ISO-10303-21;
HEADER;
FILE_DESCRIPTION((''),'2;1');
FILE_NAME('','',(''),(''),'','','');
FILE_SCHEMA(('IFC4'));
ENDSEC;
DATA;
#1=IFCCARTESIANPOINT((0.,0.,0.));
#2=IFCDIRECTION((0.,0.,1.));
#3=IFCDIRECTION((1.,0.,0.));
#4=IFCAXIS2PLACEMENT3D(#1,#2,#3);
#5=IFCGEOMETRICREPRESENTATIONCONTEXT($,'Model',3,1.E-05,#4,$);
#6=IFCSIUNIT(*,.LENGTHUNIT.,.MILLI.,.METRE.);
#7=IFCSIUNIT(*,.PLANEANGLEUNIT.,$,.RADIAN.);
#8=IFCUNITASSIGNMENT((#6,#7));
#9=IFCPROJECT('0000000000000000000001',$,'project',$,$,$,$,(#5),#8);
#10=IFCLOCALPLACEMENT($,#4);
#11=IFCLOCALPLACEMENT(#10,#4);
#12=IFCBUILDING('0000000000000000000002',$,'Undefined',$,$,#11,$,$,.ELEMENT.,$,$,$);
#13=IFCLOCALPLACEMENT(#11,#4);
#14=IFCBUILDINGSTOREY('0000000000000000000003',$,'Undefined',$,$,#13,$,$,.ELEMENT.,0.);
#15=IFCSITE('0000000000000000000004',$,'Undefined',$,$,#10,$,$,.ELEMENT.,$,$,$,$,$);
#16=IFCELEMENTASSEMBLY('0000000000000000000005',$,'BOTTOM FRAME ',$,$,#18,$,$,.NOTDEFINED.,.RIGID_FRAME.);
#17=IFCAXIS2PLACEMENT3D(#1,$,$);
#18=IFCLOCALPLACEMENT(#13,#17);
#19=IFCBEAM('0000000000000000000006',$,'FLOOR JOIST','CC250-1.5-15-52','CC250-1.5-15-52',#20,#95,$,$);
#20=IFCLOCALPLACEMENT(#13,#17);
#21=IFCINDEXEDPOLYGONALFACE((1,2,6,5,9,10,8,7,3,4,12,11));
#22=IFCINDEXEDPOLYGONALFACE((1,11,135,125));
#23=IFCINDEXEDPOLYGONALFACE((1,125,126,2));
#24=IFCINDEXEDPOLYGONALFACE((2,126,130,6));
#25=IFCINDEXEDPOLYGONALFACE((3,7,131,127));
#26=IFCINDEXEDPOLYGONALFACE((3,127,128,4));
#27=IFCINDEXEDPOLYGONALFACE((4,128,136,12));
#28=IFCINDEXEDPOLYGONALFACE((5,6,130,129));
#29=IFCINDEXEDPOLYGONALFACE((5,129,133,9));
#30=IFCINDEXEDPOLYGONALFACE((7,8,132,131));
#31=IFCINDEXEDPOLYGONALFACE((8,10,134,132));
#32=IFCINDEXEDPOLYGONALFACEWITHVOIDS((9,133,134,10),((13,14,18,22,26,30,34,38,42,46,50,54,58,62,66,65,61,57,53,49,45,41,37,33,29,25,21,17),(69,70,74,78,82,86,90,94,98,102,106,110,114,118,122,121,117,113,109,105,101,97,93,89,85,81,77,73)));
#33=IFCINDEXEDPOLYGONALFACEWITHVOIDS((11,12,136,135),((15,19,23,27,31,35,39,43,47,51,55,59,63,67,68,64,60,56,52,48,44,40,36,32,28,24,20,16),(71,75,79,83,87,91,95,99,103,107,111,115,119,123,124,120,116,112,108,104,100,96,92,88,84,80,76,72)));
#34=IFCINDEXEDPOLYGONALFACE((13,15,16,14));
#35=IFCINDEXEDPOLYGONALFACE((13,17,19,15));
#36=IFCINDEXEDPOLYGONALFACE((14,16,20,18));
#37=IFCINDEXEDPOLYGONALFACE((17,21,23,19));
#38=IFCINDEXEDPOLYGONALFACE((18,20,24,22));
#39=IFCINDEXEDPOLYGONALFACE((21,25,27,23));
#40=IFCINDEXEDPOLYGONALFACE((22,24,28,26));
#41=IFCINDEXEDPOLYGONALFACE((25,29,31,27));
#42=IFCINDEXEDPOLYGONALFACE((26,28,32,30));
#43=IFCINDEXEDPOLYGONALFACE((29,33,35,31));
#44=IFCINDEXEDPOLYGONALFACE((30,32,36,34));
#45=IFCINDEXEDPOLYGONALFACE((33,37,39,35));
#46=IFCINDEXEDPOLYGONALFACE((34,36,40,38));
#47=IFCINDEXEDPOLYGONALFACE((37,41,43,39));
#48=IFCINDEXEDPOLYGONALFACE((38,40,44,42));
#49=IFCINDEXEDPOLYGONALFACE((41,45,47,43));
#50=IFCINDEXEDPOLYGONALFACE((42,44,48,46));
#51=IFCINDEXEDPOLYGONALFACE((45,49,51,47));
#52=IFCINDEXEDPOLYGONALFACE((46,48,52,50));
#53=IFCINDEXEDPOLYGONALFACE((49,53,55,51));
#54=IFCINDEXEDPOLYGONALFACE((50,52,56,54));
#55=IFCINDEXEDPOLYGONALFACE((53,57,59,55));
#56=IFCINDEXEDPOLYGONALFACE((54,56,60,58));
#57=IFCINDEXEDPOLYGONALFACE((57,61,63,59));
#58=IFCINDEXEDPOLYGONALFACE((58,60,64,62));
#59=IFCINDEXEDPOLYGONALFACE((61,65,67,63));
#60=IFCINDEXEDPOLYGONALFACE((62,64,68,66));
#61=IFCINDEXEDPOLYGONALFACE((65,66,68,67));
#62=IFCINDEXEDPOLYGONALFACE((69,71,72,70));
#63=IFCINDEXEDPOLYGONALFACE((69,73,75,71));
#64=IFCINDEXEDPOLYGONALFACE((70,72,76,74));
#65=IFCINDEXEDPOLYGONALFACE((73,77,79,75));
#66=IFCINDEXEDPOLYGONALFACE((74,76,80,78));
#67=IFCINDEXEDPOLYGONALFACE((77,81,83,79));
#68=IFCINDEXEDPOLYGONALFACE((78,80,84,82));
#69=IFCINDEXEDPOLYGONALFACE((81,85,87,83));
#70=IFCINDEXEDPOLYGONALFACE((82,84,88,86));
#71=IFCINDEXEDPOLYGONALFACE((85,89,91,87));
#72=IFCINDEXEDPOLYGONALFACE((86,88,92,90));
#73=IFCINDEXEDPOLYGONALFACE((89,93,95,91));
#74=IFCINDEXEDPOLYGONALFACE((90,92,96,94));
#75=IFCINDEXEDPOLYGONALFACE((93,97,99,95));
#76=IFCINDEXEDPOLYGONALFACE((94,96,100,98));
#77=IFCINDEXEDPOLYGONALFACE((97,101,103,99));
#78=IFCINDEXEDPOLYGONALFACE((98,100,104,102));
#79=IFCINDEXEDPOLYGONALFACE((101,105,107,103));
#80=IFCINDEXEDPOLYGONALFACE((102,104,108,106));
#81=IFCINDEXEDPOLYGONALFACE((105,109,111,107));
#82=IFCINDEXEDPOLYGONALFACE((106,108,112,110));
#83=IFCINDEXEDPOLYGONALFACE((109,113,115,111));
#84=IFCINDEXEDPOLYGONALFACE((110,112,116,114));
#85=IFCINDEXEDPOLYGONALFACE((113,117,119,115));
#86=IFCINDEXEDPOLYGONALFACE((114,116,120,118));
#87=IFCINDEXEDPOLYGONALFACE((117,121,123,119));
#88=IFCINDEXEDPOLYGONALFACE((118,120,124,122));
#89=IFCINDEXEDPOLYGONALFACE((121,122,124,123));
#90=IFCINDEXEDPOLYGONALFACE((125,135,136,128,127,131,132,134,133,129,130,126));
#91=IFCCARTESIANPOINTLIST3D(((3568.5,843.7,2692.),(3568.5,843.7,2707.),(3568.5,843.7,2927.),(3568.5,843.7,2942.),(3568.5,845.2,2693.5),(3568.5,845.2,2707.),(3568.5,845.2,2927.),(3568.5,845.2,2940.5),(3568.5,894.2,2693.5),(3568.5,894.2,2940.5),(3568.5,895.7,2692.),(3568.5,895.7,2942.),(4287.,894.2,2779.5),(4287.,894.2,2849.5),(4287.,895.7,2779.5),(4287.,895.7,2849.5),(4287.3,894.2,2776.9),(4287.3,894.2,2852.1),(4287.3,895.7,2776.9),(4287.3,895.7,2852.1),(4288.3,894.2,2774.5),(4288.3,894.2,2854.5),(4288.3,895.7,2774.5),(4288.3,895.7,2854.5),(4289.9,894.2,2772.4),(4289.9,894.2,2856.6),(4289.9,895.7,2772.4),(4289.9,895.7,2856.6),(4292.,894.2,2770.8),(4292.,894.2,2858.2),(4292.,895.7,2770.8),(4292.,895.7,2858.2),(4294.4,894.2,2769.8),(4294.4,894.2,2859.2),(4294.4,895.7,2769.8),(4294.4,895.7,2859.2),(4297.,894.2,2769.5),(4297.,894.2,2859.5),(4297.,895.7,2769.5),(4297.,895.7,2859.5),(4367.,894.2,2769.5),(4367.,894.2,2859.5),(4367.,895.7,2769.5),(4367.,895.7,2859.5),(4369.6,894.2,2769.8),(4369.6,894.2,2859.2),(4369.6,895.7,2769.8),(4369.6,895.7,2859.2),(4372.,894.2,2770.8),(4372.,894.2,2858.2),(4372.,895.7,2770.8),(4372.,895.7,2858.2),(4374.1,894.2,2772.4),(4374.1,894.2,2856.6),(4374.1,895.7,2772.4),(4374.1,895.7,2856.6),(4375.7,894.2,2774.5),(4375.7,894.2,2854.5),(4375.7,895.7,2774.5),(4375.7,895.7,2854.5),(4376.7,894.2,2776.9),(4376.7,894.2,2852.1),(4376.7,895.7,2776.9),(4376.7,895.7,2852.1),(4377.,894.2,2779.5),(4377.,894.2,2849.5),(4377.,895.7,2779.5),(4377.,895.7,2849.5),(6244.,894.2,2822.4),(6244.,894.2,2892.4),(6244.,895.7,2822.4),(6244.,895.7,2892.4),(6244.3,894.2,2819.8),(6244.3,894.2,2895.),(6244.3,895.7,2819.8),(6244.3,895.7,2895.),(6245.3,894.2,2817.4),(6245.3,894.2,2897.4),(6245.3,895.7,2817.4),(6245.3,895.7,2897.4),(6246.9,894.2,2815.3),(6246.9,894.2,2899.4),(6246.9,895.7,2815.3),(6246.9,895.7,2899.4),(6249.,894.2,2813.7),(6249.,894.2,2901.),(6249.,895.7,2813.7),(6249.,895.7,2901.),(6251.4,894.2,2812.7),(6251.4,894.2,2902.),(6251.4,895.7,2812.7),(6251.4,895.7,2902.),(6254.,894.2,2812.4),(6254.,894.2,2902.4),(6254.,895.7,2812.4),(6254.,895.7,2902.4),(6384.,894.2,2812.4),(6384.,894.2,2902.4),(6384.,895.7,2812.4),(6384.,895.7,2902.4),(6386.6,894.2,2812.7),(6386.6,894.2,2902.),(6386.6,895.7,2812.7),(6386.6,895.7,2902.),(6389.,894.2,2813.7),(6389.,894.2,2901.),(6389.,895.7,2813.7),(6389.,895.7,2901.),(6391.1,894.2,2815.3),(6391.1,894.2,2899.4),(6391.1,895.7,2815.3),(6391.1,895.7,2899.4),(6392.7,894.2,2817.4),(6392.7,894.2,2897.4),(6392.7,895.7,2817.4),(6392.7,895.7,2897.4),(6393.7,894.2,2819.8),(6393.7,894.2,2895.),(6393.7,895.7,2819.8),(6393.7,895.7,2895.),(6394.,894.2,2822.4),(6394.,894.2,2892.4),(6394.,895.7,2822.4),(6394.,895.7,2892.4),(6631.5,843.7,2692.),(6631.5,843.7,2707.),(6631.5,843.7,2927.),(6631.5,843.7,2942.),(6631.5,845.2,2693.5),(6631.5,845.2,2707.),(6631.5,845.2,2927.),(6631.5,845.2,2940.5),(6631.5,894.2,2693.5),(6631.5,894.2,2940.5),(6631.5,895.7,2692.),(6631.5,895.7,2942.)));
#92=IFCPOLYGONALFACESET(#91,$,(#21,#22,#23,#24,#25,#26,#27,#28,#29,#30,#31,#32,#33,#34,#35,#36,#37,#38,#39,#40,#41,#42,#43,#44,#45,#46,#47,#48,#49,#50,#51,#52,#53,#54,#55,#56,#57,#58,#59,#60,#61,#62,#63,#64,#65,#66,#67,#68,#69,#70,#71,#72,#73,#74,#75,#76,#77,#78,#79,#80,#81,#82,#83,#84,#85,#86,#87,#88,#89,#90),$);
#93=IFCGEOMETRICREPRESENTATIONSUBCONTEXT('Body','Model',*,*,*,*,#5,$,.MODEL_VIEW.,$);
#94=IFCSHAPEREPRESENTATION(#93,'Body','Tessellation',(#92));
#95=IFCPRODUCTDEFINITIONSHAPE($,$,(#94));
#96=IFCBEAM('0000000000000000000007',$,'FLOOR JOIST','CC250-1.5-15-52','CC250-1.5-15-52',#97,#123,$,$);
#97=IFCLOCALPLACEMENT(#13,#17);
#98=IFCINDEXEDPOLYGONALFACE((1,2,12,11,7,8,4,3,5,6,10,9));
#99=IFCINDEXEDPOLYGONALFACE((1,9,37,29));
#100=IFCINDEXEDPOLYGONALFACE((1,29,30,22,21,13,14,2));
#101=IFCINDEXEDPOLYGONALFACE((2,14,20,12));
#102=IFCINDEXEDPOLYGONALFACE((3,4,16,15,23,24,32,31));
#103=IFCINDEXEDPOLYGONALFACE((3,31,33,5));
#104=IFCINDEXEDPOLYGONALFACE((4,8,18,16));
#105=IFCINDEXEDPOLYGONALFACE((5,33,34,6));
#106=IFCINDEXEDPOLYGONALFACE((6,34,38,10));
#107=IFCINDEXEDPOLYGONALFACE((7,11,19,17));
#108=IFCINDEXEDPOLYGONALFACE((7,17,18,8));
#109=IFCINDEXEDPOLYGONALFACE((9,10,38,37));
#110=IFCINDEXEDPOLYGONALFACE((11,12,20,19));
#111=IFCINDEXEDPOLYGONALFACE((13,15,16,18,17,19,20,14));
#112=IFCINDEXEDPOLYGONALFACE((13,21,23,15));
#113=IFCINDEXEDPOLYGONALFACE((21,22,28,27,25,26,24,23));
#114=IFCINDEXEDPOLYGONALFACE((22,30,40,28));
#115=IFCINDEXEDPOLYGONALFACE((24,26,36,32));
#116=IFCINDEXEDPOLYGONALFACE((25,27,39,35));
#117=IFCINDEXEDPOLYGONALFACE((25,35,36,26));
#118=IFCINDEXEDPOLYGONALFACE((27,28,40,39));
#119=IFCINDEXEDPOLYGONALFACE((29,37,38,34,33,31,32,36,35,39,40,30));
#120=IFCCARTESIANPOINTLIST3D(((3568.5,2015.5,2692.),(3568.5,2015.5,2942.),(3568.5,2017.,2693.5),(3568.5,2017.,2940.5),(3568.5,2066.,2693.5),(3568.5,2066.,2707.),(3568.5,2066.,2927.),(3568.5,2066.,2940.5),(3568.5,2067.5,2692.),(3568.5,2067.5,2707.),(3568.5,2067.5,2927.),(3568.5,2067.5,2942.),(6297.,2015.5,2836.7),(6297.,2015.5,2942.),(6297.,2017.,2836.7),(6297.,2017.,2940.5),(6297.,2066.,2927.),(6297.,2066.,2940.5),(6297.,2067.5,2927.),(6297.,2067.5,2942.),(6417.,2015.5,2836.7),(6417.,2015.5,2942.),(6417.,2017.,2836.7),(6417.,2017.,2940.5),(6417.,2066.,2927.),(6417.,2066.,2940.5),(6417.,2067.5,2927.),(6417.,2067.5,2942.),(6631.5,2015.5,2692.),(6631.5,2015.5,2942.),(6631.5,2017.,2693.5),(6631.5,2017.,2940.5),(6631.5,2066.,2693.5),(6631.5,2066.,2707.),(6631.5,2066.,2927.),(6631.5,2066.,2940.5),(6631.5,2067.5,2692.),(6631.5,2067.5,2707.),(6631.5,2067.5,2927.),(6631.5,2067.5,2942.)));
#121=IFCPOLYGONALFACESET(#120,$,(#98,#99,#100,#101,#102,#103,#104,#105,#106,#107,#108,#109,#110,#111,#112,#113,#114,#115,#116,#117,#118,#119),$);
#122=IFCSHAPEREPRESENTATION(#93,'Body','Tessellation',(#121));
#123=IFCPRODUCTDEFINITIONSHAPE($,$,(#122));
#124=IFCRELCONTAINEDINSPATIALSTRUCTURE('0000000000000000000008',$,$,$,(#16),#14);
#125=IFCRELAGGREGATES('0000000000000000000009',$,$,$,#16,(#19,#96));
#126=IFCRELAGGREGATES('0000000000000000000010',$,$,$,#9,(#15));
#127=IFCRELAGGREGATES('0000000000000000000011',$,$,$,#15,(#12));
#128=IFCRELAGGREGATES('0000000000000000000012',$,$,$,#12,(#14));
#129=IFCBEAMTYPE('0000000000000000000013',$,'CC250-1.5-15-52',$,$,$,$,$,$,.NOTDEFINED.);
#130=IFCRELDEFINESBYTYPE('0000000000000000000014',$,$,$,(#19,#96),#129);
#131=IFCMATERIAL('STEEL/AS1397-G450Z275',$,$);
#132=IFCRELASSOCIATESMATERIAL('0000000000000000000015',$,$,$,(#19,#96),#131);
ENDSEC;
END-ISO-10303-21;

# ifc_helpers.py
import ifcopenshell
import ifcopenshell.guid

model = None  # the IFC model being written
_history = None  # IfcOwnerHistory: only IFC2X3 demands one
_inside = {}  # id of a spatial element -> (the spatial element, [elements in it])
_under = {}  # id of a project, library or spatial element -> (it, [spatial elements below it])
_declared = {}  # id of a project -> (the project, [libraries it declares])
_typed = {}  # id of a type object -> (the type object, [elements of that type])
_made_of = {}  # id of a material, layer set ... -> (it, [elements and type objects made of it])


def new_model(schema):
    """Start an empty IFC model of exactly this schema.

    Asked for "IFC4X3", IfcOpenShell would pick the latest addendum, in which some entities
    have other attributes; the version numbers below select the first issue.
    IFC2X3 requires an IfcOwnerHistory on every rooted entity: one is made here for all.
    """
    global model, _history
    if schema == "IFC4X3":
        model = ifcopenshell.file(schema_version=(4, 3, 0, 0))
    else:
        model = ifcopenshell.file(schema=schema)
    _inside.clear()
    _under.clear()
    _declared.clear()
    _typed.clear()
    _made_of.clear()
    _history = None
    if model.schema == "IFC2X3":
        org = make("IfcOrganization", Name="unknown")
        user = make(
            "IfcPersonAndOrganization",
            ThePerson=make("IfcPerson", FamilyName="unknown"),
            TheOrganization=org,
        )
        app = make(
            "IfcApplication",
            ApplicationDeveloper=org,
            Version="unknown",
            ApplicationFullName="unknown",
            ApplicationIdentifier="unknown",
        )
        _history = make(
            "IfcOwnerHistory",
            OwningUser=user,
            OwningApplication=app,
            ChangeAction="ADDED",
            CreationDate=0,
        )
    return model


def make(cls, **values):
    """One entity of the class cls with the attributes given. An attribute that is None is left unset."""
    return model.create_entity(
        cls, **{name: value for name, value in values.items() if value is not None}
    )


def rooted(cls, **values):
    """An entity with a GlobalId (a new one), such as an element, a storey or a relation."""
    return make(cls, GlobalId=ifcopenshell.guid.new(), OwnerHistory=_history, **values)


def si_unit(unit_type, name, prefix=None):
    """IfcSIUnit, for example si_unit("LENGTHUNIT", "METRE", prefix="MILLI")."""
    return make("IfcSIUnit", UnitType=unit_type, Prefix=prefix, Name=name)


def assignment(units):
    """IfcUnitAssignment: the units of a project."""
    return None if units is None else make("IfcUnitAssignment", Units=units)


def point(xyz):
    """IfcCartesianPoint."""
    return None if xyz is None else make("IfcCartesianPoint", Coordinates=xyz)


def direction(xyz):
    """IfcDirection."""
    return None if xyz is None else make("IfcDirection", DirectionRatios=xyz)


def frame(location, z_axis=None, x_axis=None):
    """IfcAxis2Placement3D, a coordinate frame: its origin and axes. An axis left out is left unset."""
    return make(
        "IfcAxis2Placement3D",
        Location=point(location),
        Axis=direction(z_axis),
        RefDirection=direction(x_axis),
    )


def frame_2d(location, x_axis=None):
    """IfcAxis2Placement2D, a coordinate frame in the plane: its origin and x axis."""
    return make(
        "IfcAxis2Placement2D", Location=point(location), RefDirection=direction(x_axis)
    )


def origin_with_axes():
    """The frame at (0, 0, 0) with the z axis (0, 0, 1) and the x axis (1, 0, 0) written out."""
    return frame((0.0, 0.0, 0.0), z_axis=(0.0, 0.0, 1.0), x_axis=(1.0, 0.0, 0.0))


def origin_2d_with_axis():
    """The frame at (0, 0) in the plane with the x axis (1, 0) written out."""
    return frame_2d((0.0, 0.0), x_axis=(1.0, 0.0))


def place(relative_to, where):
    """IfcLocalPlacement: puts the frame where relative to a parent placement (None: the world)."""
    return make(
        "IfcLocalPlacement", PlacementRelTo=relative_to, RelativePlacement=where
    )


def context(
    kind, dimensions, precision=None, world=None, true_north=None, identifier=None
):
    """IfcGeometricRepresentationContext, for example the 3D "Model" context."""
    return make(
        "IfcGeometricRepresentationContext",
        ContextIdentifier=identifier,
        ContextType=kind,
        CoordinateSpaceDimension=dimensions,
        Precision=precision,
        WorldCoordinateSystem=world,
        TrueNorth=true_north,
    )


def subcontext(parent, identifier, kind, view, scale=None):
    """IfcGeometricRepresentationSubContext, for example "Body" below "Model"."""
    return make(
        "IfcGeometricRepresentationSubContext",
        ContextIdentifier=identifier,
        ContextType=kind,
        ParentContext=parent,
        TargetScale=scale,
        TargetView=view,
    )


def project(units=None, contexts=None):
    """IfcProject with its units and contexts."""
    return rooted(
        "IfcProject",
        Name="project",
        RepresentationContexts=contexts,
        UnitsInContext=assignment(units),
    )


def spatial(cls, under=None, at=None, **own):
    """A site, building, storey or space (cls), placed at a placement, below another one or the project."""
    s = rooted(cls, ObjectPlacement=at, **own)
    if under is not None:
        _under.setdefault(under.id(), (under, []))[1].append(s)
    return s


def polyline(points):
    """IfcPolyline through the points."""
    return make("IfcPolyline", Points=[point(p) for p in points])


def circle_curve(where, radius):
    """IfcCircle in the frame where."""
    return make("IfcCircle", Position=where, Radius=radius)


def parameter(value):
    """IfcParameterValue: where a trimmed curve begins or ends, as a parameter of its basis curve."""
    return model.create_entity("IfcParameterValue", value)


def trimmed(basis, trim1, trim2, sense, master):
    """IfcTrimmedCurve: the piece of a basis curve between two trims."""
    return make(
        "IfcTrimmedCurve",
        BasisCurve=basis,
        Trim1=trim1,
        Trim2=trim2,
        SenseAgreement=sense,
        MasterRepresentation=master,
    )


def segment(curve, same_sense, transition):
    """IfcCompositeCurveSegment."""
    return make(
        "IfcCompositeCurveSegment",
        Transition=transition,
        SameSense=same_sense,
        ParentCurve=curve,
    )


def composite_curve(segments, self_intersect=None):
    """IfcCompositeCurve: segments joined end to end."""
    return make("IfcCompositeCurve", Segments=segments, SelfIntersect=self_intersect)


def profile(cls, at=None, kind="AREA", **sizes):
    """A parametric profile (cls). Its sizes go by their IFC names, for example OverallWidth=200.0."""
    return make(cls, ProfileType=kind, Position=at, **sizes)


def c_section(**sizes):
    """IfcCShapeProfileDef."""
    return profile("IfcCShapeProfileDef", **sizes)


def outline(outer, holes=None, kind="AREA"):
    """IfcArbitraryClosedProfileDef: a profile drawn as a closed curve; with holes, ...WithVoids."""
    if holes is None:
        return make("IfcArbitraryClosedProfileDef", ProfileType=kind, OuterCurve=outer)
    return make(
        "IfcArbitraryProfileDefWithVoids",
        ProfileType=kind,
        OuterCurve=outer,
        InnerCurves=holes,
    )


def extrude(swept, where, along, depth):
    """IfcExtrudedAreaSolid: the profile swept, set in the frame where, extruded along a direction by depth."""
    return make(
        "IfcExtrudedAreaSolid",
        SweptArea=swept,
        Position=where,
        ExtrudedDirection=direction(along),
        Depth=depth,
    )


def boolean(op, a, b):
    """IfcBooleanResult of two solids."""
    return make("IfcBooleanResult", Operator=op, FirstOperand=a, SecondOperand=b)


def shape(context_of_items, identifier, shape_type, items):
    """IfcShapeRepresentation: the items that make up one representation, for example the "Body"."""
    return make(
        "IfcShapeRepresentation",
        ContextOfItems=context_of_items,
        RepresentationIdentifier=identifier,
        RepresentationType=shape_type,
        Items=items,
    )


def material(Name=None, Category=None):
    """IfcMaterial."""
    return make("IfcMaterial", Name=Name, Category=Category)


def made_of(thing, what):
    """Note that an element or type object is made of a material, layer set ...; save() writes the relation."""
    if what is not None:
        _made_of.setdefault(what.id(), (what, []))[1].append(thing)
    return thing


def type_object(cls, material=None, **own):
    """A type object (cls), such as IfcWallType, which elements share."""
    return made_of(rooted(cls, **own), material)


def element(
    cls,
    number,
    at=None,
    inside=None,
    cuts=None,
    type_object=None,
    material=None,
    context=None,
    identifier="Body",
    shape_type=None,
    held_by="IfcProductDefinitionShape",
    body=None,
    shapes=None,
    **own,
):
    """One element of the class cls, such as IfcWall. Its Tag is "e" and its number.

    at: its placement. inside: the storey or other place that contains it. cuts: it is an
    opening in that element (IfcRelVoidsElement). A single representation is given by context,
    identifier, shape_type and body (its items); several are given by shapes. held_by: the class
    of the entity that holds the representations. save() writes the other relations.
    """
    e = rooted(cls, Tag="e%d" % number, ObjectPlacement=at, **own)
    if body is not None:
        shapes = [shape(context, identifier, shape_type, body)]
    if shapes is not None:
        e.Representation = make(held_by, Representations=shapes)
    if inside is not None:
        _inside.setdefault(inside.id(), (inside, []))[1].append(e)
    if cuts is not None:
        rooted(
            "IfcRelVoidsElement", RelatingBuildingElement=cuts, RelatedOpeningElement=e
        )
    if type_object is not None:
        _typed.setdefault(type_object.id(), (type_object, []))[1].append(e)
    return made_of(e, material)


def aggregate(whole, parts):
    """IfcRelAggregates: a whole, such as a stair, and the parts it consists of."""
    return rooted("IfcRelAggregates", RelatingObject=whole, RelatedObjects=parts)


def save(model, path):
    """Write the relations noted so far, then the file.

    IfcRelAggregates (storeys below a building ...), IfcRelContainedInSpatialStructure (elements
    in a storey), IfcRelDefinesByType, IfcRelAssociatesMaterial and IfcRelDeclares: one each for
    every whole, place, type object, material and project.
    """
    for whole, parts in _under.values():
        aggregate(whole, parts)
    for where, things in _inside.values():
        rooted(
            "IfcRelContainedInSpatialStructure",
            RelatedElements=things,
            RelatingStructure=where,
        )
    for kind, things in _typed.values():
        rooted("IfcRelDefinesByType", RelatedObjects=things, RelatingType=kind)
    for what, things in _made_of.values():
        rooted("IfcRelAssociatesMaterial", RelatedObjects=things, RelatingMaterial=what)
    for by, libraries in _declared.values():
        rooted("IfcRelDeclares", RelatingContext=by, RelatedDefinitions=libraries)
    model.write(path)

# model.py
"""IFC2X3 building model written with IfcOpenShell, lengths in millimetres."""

from ifc_helpers import new_model, si_unit, frame, frame_2d, origin_with_axes, origin_2d_with_axis, place, context, subcontext, project, spatial, polyline, circle_curve, parameter, trimmed, segment, composite_curve, c_section, outline, extrude, boolean, material, type_object, element, aggregate, save


model = new_model("IFC2X3")

# Units and contexts
model_context = context("Model", 3, precision=1e-05, world=origin_with_axes())
body_context = subcontext(model_context, "Body", "Model", "MODEL_VIEW")
ifc_project = project(units=[si_unit("LENGTHUNIT", "METRE", prefix="MILLI"), si_unit("PLANEANGLEUNIT", "RADIAN")], contexts=[model_context])

# Site, building, storey
site_placement = place(None, origin_with_axes())
site = spatial("IfcSite", under=ifc_project, at=site_placement, Name="Undefined", CompositionType="ELEMENT")
building_placement = place(site_placement, origin_with_axes())
building = spatial("IfcBuilding", under=site, at=building_placement, Name="Undefined", CompositionType="ELEMENT")
storey_placement = place(building_placement, origin_with_axes())
storey = spatial("IfcBuildingStorey", under=building, at=storey_placement, Name="Undefined", CompositionType="ELEMENT", Elevation=0.0)

# Element assembly, beams
assembly_1_placement = place(storey_placement, origin_with_axes())
assembly_1 = element("IfcElementAssembly", 1, at=assembly_1_placement, inside=storey, Name="BOTTOM FRAME ", AssemblyPlace="NOTDEFINED", PredefinedType="RIGID_FRAME")
ifc_material_1 = material(Name="STEEL/AS1397-G450Z275")
beam_type_1 = type_object("IfcBeamType", Name="CC250-1.5-15-52", PredefinedType="NOTDEFINED")
beam_1_placement = place(assembly_1_placement, frame((3568.5, 869.7, 2817.0), z_axis=(0.0, 0.0, 1.0), x_axis=(1.0, 0.0, 0.0)))
beam_1 = element("IfcBeam", 2, at=beam_1_placement, type_object=beam_type_1, material=ifc_material_1, Name="FLOOR JOIST", Description="CC250-1.5-15-52", ObjectType="CC250-1.5-15-52", context=body_context, shape_type="CSG", body=[
    boolean("DIFFERENCE", boolean("DIFFERENCE", extrude(c_section(Depth=250.0, Width=52.0, WallThickness=1.5, Girth=15.0, at=origin_2d_with_axis()), frame((3063.0, 0.0, 0.0), z_axis=(-1.0, 0.0, 0.0), x_axis=(0.0, -1.0, 0.0)), (0.0, 0.0, 1.0), 3063.0), extrude(outline(composite_curve([segment(trimmed(circle_curve(frame_2d((10.0, 10.0), x_axis=(-1.0, 0.0)), 10.0), [parameter(0.0)], [parameter(1.570796)], True, "PARAMETER"), True, "CONTINUOUS"), segment(polyline([(10.0, 0.0), (80.0, 0.0)]), True, "CONTINUOUS"), segment(trimmed(circle_curve(frame_2d((80.0, 10.0), x_axis=(0.0, -1.0)), 10.0), [parameter(0.0)], [parameter(1.570796)], True, "PARAMETER"), True, "CONTINUOUS"), segment(polyline([(90.0, 10.0), (90.0, 80.0)]), True, "CONTINUOUS"), segment(trimmed(circle_curve(frame_2d((80.0, 80.0), x_axis=(1.0, 0.0)), 10.0), [parameter(0.0)], [parameter(1.570796)], True, "PARAMETER"), True, "CONTINUOUS"), segment(polyline([(80.0, 90.0), (10.0, 90.0)]), True, "CONTINUOUS"), segment(trimmed(circle_curve(frame_2d((10.0, 80.0), x_axis=(0.0, 1.0)), 10.0), [parameter(0.0)], [parameter(1.570796)], True, "PARAMETER"), True, "CONTINUOUS"), segment(polyline([(0.0, 80.0), (0.0, 10.0)]), True, "CONTINUOUS")], self_intersect=True)), frame((718.5, -40.5, 42.5), z_axis=(0.0, 1.0, 0.0), x_axis=(1.0, 0.0, 0.0)), (0.0, 0.0, 1.0), 81.0)), extrude(outline(composite_curve([segment(trimmed(circle_curve(frame_2d((10.0, 10.0), x_axis=(-1.0, 0.0)), 10.0), [parameter(0.0)], [parameter(1.570796)], True, "PARAMETER"), True, "CONTINUOUS"), segment(polyline([(10.0, 0.0), (140.0, 0.0)]), True, "CONTINUOUS"), segment(trimmed(circle_curve(frame_2d((140.0, 10.0), x_axis=(0.0, -1.0)), 10.0), [parameter(0.0)], [parameter(1.570796)], True, "PARAMETER"), True, "CONTINUOUS"), segment(polyline([(150.0, 10.0), (150.0, 80.0)]), True, "CONTINUOUS"), segment(trimmed(circle_curve(frame_2d((140.0, 80.0), x_axis=(1.0, 0.0)), 10.0), [parameter(0.0)], [parameter(1.570796)], True, "PARAMETER"), True, "CONTINUOUS"), segment(polyline([(140.0, 90.0), (10.0, 90.0)]), True, "CONTINUOUS"), segment(trimmed(circle_curve(frame_2d((10.0, 80.0), x_axis=(0.0, 1.0)), 10.0), [parameter(0.0)], [parameter(1.570796)], True, "PARAMETER"), True, "CONTINUOUS"), segment(polyline([(0.0, 80.0), (0.0, 10.0)]), True, "CONTINUOUS")], self_intersect=True)), frame((2675.5, -40.5, 85.4), z_axis=(0.0, 1.0, 0.0), x_axis=(1.0, 0.0, 0.0)), (0.0, 0.0, 1.0), 81.0)),
])
beam_2_placement = place(assembly_1_placement, frame((3568.5, 2041.5, 2817.0), z_axis=(0.0, 0.0, -1.0), x_axis=(1.0, 0.0, 0.0)))
beam_2 = element("IfcBeam", 3, at=beam_2_placement, type_object=beam_type_1, material=ifc_material_1, Name="FLOOR JOIST", Description="CC250-1.5-15-52", ObjectType="CC250-1.5-15-52", context=body_context, shape_type="CSG", body=[
    boolean("DIFFERENCE", extrude(c_section(Depth=250.0, Width=52.0, WallThickness=1.5, Girth=15.0, at=origin_2d_with_axis()), frame((3063.0, 0.0, 0.0), z_axis=(-1.0, 0.0, 0.0), x_axis=(0.0, -1.0, 0.0)), (0.0, 0.0, 1.0), 3063.0), extrude(outline(polyline([(0.0, 0.0), (110.0, 0.0), (110.0, 120.0), (0.0, 120.0), (0.0, 0.0)])), frame((2728.5, -40.5, -129.7), z_axis=(0.0, 1.0, 0.0), x_axis=(0.0, 0.0, 1.0)), (0.0, 0.0, 1.0), 81.0)),
])

aggregate(assembly_1, [beam_1, beam_2])

save(model, "model.ifc")
